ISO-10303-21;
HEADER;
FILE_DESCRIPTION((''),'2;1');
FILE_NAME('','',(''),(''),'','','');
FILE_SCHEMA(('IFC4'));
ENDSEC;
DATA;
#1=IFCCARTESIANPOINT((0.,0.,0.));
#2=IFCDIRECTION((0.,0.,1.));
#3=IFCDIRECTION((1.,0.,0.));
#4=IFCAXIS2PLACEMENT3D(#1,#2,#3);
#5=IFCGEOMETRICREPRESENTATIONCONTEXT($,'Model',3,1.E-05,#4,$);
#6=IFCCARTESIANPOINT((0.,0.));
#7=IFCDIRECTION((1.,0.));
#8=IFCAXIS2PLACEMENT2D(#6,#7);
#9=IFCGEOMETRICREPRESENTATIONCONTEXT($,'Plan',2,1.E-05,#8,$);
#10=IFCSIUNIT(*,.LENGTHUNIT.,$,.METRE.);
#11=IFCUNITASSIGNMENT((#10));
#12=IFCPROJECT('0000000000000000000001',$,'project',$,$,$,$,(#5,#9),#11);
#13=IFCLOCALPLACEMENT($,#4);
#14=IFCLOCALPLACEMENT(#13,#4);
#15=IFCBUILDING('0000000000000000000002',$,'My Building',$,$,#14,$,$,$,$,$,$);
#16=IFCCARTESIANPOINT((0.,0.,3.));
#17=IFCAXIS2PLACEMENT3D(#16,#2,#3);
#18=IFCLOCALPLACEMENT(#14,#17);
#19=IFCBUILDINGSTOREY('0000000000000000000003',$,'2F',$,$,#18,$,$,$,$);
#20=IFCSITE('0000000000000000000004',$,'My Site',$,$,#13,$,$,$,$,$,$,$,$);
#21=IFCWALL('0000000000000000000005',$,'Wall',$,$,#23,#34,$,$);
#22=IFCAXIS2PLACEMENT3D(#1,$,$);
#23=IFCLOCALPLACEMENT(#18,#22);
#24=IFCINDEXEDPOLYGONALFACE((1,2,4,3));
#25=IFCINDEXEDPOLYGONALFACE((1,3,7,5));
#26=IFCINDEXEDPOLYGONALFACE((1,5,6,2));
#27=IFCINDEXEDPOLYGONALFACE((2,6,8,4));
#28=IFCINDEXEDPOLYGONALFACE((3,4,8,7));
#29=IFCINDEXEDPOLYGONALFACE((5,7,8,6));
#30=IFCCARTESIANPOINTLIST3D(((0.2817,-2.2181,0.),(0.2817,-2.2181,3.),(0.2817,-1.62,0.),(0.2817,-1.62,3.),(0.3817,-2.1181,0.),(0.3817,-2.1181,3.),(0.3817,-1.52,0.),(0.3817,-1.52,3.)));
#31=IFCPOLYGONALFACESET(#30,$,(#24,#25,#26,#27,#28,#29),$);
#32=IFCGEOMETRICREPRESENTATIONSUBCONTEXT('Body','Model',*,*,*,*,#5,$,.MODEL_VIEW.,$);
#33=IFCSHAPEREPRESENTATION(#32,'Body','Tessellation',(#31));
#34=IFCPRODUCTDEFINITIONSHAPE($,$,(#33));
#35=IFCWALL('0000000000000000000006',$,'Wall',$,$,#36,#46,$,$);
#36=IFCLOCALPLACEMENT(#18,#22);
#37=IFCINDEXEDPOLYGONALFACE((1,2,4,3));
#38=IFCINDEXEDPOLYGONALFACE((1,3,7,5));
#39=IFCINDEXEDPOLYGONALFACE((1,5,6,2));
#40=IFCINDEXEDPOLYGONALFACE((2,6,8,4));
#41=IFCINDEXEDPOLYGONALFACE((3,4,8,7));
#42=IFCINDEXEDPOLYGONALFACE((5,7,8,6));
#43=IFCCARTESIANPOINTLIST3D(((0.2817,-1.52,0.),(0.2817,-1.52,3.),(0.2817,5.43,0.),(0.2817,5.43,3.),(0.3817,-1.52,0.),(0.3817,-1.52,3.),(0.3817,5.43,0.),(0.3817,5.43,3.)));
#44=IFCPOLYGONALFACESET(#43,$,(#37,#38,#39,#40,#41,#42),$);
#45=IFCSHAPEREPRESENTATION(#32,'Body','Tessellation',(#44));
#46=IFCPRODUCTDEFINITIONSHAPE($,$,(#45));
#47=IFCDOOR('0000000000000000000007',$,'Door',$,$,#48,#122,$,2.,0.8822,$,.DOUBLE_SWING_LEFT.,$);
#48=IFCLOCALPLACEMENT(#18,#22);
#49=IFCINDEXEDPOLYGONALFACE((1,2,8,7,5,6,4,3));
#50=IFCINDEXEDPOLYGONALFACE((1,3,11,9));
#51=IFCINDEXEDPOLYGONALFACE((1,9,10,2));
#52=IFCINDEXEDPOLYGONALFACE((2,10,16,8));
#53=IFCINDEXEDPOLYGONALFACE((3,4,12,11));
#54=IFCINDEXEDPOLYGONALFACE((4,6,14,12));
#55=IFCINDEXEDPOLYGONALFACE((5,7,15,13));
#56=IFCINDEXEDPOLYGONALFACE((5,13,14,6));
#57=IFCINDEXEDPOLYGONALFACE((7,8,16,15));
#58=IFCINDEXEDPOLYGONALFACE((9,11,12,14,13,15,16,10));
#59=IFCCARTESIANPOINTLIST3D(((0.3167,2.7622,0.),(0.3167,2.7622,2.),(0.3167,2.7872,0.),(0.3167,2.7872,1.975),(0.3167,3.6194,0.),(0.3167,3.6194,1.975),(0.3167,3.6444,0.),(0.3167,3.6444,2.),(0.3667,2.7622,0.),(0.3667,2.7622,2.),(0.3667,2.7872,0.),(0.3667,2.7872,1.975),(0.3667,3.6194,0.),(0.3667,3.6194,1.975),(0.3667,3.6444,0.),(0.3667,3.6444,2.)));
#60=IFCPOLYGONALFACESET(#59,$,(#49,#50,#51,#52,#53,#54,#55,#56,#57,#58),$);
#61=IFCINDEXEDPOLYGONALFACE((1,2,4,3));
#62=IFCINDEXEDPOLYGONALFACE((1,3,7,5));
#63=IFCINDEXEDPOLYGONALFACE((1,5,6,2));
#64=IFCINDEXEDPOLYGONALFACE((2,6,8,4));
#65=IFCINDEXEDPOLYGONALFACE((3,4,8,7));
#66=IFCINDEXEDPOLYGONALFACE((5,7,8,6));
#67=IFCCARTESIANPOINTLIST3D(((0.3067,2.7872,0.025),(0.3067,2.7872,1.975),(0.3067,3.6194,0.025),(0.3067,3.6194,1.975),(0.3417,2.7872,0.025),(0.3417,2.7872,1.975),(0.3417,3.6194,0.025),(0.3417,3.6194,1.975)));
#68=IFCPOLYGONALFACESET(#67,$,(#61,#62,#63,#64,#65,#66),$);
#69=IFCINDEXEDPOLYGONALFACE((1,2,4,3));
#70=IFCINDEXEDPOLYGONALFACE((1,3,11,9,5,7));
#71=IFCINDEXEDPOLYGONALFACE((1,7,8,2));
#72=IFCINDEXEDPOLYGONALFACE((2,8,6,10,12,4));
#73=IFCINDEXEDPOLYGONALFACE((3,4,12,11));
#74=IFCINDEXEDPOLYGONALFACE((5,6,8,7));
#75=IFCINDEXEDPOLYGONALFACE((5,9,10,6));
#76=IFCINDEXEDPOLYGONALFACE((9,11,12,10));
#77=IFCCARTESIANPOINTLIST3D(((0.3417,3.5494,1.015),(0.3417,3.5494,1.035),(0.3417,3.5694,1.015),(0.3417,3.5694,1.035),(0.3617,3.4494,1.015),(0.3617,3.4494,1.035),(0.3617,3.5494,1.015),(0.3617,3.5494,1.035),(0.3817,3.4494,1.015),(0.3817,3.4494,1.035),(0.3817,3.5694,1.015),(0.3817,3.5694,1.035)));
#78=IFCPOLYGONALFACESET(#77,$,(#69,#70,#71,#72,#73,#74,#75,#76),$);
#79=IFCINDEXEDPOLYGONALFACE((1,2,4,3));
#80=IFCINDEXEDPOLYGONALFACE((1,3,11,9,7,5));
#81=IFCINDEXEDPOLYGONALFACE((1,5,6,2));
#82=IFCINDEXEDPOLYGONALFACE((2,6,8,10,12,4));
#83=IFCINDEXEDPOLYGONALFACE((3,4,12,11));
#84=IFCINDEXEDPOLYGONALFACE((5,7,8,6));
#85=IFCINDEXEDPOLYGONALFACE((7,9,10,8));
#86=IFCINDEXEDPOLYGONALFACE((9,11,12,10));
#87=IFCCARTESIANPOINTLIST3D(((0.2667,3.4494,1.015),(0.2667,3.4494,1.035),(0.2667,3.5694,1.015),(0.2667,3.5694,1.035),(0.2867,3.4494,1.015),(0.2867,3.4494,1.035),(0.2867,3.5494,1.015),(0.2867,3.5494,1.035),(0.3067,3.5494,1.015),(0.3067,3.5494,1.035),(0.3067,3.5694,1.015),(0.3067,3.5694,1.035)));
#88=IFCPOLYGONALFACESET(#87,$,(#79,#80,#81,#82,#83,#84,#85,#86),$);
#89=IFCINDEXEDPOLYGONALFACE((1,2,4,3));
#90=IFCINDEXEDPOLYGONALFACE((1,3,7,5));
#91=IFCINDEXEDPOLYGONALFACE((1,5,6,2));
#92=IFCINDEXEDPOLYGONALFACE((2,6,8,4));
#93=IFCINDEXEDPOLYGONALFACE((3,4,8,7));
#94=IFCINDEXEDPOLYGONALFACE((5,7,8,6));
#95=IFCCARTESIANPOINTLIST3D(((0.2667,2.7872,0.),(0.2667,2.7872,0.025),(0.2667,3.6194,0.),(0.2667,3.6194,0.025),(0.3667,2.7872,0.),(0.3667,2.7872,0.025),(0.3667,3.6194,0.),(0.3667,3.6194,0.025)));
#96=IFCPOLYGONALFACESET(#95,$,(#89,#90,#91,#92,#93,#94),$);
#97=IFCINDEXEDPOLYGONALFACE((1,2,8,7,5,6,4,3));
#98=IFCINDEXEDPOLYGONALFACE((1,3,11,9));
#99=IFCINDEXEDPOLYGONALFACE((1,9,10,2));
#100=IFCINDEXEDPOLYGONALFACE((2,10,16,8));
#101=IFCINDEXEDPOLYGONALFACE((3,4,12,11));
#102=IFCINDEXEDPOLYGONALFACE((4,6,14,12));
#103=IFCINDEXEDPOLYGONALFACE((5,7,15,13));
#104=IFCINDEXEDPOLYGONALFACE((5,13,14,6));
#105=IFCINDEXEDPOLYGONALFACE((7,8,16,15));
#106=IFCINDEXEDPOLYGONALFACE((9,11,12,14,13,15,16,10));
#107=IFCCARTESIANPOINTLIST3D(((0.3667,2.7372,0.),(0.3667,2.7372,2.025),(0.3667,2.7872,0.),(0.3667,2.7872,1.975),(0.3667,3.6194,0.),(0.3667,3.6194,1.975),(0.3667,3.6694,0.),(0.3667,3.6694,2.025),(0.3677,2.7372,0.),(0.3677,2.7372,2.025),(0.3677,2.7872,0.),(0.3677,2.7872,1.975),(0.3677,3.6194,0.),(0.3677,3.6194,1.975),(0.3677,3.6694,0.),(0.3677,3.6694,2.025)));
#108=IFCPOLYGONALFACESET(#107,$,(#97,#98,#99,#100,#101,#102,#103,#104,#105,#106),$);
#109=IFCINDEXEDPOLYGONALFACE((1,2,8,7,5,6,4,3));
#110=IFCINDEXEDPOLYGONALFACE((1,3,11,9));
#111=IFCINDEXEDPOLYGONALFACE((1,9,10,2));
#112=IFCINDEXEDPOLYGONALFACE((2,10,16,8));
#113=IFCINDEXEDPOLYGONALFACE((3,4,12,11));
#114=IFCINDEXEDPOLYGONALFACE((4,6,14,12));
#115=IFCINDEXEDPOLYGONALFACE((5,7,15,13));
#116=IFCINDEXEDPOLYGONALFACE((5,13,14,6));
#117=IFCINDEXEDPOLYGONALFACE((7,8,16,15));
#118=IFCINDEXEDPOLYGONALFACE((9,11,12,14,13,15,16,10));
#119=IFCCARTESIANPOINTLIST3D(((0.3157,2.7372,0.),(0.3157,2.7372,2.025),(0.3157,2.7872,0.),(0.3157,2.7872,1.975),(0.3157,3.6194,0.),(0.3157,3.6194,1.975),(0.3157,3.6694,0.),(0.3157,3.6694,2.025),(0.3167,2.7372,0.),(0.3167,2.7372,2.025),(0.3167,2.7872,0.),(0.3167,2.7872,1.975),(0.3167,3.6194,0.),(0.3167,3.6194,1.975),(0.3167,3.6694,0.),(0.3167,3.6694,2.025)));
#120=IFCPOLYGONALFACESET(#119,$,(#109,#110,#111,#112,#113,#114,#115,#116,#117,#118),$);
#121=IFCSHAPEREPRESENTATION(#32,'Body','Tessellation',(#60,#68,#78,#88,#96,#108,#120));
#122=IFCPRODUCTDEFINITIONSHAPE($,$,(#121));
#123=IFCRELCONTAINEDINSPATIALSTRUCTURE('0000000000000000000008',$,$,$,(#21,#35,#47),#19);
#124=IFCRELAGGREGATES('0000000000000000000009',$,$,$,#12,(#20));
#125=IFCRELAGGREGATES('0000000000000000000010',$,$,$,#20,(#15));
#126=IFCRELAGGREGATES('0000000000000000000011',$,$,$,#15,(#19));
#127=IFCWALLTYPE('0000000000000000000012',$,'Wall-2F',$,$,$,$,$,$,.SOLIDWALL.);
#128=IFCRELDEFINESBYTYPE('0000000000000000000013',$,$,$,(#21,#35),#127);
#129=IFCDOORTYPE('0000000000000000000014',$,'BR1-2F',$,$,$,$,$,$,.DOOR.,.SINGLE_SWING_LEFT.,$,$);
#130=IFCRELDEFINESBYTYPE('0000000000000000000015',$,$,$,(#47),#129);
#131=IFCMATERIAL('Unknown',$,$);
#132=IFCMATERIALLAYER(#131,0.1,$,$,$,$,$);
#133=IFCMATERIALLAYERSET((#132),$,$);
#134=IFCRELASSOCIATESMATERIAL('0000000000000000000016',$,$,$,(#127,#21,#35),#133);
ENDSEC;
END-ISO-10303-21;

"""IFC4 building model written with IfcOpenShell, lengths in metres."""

from ifc_helpers import new_model, entity, si_unit, frame, origin_with_axes, origin_2d_with_axis, place, context, subcontext, project, spatial, line, indexed_curve, outline, extrude, shape, source, transform, mapped, material, layer, layer_set, layer_usage, type_object, type_shapes, element, save


model = new_model("IFC4")

# Units and contexts
model_context = context("Model", 3, precision=1e-05, world=origin_with_axes())
plan_context = context("Plan", 2, precision=1e-05, world=origin_2d_with_axis())
body_context_1 = subcontext(model_context, "Body", "Model", "MODEL_VIEW")
body_context_2 = subcontext(plan_context, "Body", "Plan", "PLAN_VIEW")
ifc_project = project(units=[si_unit("LENGTHUNIT", "METRE")], contexts=[model_context, plan_context])

# Site, building, storey
site_placement = place(None, origin_with_axes())
site = spatial("IfcSite", under=ifc_project, at=site_placement, Name="My Site")
building_placement = place(site_placement, origin_with_axes())
building = spatial("IfcBuilding", under=site, at=building_placement, Name="My Building")
storey_placement = place(building_placement, frame((0.0, 0.0, 3.0), z_axis=(0.0, 0.0, 1.0), x_axis=(1.0, 0.0, 0.0)))
storey = spatial("IfcBuildingStorey", under=building, at=storey_placement, Name="2F")

# Shared definitions
ifc_material = material(Name="Unknown")

# Shared definitions
ifc_layer_1 = layer(ifc_material, 0.1)
ifc_layer_set_1 = layer_set([ifc_layer_1])
wall_type_1 = type_object("IfcWallType", Name="Wall-2F", PredefinedType="SOLIDWALL", material=ifc_layer_set_1)

# Walls
ifc_layer_usage_1 = layer_usage(ifc_layer_set_1, "AXIS2", "POSITIVE", 0.0)
wall_1_placement = place(storey_placement, frame((0.2817, -1.62, 0.0), z_axis=(0.0, 0.0, 1.0), x_axis=(0.0, -1.0, 0.0)))
element("IfcWall", 1, at=wall_1_placement, inside=storey, type_object=wall_type_1, material=ifc_layer_usage_1, Name="Wall", context=body_context_1, shape_type="SweptSolid", body=[
    extrude(outline(indexed_curve([(0.0, 0.0), (-0.1, 0.1), (0.4981, 0.1), (0.5981, 0.0)], segments=[line(1, 2, 3, 4, 1)])), origin_with_axes(), (0.0, 0.0, 1.0), 3.0),
])
ifc_layer_usage_2 = layer_usage(ifc_layer_set_1, "AXIS2", "POSITIVE", 0.0)
wall_2_placement = place(storey_placement, frame((0.3817, -1.52, 0.0), z_axis=(0.0, 0.0, 1.0), x_axis=(0.0, 1.0, 0.0)))
element("IfcWall", 2, at=wall_2_placement, inside=storey, type_object=wall_type_1, material=ifc_layer_usage_2, Name="Wall", context=body_context_1, shape_type="SweptSolid", body=[
    extrude(outline(indexed_curve([(0.0, 0.0), (0.0, 0.1), (6.95, 0.1), (6.95, 0.0)], segments=[line(1, 2, 3, 4, 1)])), origin_with_axes(), (0.0, 0.0, 1.0), 3.0),
])

# Door
door_type_1 = type_object("IfcDoorType", Name="BR1-2F", OperationType="SINGLE_SWING_LEFT", PredefinedType="DOOR")
shared_shape_1 = source(origin_with_axes(), body_context_1, "Body", "SweptSolid", [
    extrude(outline(indexed_curve([(0.0, 0.0), (0.0, 2.0), (0.8822, 2.0), (0.8822, 0.0), (0.8572, 0.0), (0.8572, 1.975), (0.025, 1.975), (0.025, 0.0)], segments=[line(1, 2, 3, 4, 5, 6, 7, 8, 1)])), frame((0.0, 0.0, 0.0), z_axis=(0.0, -1.0, 0.0), x_axis=(1.0, 0.0, 0.0)), (0.0, 0.0, -1.0), 0.05),
    extrude(outline(indexed_curve([(0.0, 0.0), (0.8322, 0.0), (0.8322, 0.035), (0.0, 0.035)], segments=[line(1, 2, 3, 4, 1)])), frame((0.025, 0.025, 0.025), z_axis=(0.0, 0.0, 1.0), x_axis=(1.0, 0.0, 0.0)), (0.0, 0.0, 1.0), 1.95),
    extrude(outline(indexed_curve([(0.0, 0.0), (0.0, -0.04), (-0.12, -0.04), (-0.12, -0.02), (-0.02, -0.02), (-0.02, 0.0)], segments=[line(1, 2, 3, 4, 5, 6, 1)])), frame((0.8072, 0.025, 1.015), z_axis=(0.0, 0.0, 1.0), x_axis=(1.0, 0.0, 0.0)), (0.0, 0.0, 1.0), 0.02),
    extrude(outline(indexed_curve([(0.0, 0.0), (0.0, 0.04), (-0.12, 0.04), (-0.12, 0.02), (-0.02, 0.02), (-0.02, 0.0)], segments=[line(1, 2, 3, 4, 5, 6, 1)])), frame((0.8072, 0.06, 1.015), z_axis=(0.0, 0.0, 1.0), x_axis=(1.0, 0.0, 0.0)), (0.0, 0.0, 1.0), 0.02),
    extrude(outline(indexed_curve([(0.0, 0.0), (0.8322, 0.0), (0.8322, 0.1), (0.0, 0.1)], segments=[line(1, 2, 3, 4, 1)])), frame((0.025, 0.0, 0.0), z_axis=(0.0, 0.0, 1.0), x_axis=(1.0, 0.0, 0.0)), (0.0, 0.0, 1.0), 0.025),
    extrude(outline(indexed_curve([(0.0, 0.0), (0.0, 2.025), (0.9322, 2.025), (0.9322, 0.0), (0.8822, 0.0), (0.8822, 1.975), (0.05, 1.975), (0.05, 0.0)], segments=[line(1, 2, 3, 4, 5, 6, 7, 8, 1)])), frame((-0.025, -0.001, 0.0), z_axis=(0.0, -1.0, 0.0), x_axis=(1.0, 0.0, 0.0)), (0.0, 0.0, -1.0), 0.001),
    extrude(outline(indexed_curve([(0.0, 0.0), (0.0, 2.025), (0.9322, 2.025), (0.9322, 0.0), (0.8822, 0.0), (0.8822, 1.975), (0.05, 1.975), (0.05, 0.0)], segments=[line(1, 2, 3, 4, 5, 6, 7, 8, 1)])), frame((-0.025, 0.05, 0.0), z_axis=(0.0, -1.0, 0.0), x_axis=(1.0, 0.0, 0.0)), (0.0, 0.0, -1.0), 0.001),
])
shared_shape_2 = source(origin_with_axes(), body_context_2, "Body", "Curve2D", [
    entity("IfcIndexedPolyCurve", entity("IfcCartesianPointList2D", [[0.0, 0.0], [0.025, 0.0], [0.025, 0.05], [0.0, 0.05]]), [entity("IfcLineIndex", [1, 2, 3, 4, 1])]),
    entity("IfcIndexedPolyCurve", entity("IfcCartesianPointList2D", [[0.8822, 0.0], [0.8572, 0.0], [0.8572, 0.05], [0.8822, 0.05]]), [entity("IfcLineIndex", [1, 2, 3, 4, 1])]),
    entity("IfcIndexedPolyCurve", entity("IfcCartesianPointList2D", [[0.025, 0.05], [0.025, -0.7822], [0.06, -0.7822]])),
    entity("IfcTrimmedCurve", entity("IfcEllipse", entity("IfcAxis2Placement2D", entity("IfcCartesianPoint", [0.06, 0.05]), entity("IfcDirection", [1.0, 0.0])), 0.7972, 0.8322), [entity("IfcCartesianPoint", [0.06, -0.7822])], [entity("IfcCartesianPoint", [0.06, 0.8822])], True, "CARTESIAN"),
    entity("IfcIndexedPolyCurve", entity("IfcCartesianPointList2D", [[0.025, 0.05], [0.06, 0.05], [0.06, 0.8822], [0.025, 0.8822]]), [entity("IfcLineIndex", [1, 2, 3, 4, 1])]),
])
type_shapes(door_type_1, [shared_shape_1, shared_shape_2])
placement_1 = place(storey_placement, frame((0.2817, 6.52, 0.0), z_axis=(0.0, 0.0, 1.0), x_axis=(0.0, -1.0, 0.0)))
placement_2 = place(placement_1, frame((3.7578, 0.085, 0.0), z_axis=(0.0, 0.0, 1.0), x_axis=(-1.0, 0.0, 0.0)))
door_1_placement = place(placement_2, frame((0.0, 0.0, 0.0), z_axis=(0.0, 0.0, 1.0), x_axis=(1.0, 0.0, 0.0)))
element("IfcDoor", 3, at=door_1_placement, inside=storey, type_object=door_type_1, Name="Door", OperationType="DOUBLE_SWING_LEFT", OverallHeight=2.0, OverallWidth=0.8822, shapes=[
    shape(body_context_1, "Body", "MappedRepresentation", [mapped(shared_shape_1, transform((0.0, 0.0, 0.0), x_axis=(1.0, 0.0, 0.0), y_axis=(0.0, 1.0, 0.0), z_axis=(0.0, 0.0, 1.0), scale=1.0))]),
    shape(body_context_2, "Body", "MappedRepresentation", [mapped(shared_shape_2, transform((0.0, 0.0, 0.0), x_axis=(1.0, 0.0, 0.0), y_axis=(0.0, 1.0, 0.0), z_axis=(0.0, 0.0, 1.0), scale=1.0))]),
])

save(model, "model.ifc")
